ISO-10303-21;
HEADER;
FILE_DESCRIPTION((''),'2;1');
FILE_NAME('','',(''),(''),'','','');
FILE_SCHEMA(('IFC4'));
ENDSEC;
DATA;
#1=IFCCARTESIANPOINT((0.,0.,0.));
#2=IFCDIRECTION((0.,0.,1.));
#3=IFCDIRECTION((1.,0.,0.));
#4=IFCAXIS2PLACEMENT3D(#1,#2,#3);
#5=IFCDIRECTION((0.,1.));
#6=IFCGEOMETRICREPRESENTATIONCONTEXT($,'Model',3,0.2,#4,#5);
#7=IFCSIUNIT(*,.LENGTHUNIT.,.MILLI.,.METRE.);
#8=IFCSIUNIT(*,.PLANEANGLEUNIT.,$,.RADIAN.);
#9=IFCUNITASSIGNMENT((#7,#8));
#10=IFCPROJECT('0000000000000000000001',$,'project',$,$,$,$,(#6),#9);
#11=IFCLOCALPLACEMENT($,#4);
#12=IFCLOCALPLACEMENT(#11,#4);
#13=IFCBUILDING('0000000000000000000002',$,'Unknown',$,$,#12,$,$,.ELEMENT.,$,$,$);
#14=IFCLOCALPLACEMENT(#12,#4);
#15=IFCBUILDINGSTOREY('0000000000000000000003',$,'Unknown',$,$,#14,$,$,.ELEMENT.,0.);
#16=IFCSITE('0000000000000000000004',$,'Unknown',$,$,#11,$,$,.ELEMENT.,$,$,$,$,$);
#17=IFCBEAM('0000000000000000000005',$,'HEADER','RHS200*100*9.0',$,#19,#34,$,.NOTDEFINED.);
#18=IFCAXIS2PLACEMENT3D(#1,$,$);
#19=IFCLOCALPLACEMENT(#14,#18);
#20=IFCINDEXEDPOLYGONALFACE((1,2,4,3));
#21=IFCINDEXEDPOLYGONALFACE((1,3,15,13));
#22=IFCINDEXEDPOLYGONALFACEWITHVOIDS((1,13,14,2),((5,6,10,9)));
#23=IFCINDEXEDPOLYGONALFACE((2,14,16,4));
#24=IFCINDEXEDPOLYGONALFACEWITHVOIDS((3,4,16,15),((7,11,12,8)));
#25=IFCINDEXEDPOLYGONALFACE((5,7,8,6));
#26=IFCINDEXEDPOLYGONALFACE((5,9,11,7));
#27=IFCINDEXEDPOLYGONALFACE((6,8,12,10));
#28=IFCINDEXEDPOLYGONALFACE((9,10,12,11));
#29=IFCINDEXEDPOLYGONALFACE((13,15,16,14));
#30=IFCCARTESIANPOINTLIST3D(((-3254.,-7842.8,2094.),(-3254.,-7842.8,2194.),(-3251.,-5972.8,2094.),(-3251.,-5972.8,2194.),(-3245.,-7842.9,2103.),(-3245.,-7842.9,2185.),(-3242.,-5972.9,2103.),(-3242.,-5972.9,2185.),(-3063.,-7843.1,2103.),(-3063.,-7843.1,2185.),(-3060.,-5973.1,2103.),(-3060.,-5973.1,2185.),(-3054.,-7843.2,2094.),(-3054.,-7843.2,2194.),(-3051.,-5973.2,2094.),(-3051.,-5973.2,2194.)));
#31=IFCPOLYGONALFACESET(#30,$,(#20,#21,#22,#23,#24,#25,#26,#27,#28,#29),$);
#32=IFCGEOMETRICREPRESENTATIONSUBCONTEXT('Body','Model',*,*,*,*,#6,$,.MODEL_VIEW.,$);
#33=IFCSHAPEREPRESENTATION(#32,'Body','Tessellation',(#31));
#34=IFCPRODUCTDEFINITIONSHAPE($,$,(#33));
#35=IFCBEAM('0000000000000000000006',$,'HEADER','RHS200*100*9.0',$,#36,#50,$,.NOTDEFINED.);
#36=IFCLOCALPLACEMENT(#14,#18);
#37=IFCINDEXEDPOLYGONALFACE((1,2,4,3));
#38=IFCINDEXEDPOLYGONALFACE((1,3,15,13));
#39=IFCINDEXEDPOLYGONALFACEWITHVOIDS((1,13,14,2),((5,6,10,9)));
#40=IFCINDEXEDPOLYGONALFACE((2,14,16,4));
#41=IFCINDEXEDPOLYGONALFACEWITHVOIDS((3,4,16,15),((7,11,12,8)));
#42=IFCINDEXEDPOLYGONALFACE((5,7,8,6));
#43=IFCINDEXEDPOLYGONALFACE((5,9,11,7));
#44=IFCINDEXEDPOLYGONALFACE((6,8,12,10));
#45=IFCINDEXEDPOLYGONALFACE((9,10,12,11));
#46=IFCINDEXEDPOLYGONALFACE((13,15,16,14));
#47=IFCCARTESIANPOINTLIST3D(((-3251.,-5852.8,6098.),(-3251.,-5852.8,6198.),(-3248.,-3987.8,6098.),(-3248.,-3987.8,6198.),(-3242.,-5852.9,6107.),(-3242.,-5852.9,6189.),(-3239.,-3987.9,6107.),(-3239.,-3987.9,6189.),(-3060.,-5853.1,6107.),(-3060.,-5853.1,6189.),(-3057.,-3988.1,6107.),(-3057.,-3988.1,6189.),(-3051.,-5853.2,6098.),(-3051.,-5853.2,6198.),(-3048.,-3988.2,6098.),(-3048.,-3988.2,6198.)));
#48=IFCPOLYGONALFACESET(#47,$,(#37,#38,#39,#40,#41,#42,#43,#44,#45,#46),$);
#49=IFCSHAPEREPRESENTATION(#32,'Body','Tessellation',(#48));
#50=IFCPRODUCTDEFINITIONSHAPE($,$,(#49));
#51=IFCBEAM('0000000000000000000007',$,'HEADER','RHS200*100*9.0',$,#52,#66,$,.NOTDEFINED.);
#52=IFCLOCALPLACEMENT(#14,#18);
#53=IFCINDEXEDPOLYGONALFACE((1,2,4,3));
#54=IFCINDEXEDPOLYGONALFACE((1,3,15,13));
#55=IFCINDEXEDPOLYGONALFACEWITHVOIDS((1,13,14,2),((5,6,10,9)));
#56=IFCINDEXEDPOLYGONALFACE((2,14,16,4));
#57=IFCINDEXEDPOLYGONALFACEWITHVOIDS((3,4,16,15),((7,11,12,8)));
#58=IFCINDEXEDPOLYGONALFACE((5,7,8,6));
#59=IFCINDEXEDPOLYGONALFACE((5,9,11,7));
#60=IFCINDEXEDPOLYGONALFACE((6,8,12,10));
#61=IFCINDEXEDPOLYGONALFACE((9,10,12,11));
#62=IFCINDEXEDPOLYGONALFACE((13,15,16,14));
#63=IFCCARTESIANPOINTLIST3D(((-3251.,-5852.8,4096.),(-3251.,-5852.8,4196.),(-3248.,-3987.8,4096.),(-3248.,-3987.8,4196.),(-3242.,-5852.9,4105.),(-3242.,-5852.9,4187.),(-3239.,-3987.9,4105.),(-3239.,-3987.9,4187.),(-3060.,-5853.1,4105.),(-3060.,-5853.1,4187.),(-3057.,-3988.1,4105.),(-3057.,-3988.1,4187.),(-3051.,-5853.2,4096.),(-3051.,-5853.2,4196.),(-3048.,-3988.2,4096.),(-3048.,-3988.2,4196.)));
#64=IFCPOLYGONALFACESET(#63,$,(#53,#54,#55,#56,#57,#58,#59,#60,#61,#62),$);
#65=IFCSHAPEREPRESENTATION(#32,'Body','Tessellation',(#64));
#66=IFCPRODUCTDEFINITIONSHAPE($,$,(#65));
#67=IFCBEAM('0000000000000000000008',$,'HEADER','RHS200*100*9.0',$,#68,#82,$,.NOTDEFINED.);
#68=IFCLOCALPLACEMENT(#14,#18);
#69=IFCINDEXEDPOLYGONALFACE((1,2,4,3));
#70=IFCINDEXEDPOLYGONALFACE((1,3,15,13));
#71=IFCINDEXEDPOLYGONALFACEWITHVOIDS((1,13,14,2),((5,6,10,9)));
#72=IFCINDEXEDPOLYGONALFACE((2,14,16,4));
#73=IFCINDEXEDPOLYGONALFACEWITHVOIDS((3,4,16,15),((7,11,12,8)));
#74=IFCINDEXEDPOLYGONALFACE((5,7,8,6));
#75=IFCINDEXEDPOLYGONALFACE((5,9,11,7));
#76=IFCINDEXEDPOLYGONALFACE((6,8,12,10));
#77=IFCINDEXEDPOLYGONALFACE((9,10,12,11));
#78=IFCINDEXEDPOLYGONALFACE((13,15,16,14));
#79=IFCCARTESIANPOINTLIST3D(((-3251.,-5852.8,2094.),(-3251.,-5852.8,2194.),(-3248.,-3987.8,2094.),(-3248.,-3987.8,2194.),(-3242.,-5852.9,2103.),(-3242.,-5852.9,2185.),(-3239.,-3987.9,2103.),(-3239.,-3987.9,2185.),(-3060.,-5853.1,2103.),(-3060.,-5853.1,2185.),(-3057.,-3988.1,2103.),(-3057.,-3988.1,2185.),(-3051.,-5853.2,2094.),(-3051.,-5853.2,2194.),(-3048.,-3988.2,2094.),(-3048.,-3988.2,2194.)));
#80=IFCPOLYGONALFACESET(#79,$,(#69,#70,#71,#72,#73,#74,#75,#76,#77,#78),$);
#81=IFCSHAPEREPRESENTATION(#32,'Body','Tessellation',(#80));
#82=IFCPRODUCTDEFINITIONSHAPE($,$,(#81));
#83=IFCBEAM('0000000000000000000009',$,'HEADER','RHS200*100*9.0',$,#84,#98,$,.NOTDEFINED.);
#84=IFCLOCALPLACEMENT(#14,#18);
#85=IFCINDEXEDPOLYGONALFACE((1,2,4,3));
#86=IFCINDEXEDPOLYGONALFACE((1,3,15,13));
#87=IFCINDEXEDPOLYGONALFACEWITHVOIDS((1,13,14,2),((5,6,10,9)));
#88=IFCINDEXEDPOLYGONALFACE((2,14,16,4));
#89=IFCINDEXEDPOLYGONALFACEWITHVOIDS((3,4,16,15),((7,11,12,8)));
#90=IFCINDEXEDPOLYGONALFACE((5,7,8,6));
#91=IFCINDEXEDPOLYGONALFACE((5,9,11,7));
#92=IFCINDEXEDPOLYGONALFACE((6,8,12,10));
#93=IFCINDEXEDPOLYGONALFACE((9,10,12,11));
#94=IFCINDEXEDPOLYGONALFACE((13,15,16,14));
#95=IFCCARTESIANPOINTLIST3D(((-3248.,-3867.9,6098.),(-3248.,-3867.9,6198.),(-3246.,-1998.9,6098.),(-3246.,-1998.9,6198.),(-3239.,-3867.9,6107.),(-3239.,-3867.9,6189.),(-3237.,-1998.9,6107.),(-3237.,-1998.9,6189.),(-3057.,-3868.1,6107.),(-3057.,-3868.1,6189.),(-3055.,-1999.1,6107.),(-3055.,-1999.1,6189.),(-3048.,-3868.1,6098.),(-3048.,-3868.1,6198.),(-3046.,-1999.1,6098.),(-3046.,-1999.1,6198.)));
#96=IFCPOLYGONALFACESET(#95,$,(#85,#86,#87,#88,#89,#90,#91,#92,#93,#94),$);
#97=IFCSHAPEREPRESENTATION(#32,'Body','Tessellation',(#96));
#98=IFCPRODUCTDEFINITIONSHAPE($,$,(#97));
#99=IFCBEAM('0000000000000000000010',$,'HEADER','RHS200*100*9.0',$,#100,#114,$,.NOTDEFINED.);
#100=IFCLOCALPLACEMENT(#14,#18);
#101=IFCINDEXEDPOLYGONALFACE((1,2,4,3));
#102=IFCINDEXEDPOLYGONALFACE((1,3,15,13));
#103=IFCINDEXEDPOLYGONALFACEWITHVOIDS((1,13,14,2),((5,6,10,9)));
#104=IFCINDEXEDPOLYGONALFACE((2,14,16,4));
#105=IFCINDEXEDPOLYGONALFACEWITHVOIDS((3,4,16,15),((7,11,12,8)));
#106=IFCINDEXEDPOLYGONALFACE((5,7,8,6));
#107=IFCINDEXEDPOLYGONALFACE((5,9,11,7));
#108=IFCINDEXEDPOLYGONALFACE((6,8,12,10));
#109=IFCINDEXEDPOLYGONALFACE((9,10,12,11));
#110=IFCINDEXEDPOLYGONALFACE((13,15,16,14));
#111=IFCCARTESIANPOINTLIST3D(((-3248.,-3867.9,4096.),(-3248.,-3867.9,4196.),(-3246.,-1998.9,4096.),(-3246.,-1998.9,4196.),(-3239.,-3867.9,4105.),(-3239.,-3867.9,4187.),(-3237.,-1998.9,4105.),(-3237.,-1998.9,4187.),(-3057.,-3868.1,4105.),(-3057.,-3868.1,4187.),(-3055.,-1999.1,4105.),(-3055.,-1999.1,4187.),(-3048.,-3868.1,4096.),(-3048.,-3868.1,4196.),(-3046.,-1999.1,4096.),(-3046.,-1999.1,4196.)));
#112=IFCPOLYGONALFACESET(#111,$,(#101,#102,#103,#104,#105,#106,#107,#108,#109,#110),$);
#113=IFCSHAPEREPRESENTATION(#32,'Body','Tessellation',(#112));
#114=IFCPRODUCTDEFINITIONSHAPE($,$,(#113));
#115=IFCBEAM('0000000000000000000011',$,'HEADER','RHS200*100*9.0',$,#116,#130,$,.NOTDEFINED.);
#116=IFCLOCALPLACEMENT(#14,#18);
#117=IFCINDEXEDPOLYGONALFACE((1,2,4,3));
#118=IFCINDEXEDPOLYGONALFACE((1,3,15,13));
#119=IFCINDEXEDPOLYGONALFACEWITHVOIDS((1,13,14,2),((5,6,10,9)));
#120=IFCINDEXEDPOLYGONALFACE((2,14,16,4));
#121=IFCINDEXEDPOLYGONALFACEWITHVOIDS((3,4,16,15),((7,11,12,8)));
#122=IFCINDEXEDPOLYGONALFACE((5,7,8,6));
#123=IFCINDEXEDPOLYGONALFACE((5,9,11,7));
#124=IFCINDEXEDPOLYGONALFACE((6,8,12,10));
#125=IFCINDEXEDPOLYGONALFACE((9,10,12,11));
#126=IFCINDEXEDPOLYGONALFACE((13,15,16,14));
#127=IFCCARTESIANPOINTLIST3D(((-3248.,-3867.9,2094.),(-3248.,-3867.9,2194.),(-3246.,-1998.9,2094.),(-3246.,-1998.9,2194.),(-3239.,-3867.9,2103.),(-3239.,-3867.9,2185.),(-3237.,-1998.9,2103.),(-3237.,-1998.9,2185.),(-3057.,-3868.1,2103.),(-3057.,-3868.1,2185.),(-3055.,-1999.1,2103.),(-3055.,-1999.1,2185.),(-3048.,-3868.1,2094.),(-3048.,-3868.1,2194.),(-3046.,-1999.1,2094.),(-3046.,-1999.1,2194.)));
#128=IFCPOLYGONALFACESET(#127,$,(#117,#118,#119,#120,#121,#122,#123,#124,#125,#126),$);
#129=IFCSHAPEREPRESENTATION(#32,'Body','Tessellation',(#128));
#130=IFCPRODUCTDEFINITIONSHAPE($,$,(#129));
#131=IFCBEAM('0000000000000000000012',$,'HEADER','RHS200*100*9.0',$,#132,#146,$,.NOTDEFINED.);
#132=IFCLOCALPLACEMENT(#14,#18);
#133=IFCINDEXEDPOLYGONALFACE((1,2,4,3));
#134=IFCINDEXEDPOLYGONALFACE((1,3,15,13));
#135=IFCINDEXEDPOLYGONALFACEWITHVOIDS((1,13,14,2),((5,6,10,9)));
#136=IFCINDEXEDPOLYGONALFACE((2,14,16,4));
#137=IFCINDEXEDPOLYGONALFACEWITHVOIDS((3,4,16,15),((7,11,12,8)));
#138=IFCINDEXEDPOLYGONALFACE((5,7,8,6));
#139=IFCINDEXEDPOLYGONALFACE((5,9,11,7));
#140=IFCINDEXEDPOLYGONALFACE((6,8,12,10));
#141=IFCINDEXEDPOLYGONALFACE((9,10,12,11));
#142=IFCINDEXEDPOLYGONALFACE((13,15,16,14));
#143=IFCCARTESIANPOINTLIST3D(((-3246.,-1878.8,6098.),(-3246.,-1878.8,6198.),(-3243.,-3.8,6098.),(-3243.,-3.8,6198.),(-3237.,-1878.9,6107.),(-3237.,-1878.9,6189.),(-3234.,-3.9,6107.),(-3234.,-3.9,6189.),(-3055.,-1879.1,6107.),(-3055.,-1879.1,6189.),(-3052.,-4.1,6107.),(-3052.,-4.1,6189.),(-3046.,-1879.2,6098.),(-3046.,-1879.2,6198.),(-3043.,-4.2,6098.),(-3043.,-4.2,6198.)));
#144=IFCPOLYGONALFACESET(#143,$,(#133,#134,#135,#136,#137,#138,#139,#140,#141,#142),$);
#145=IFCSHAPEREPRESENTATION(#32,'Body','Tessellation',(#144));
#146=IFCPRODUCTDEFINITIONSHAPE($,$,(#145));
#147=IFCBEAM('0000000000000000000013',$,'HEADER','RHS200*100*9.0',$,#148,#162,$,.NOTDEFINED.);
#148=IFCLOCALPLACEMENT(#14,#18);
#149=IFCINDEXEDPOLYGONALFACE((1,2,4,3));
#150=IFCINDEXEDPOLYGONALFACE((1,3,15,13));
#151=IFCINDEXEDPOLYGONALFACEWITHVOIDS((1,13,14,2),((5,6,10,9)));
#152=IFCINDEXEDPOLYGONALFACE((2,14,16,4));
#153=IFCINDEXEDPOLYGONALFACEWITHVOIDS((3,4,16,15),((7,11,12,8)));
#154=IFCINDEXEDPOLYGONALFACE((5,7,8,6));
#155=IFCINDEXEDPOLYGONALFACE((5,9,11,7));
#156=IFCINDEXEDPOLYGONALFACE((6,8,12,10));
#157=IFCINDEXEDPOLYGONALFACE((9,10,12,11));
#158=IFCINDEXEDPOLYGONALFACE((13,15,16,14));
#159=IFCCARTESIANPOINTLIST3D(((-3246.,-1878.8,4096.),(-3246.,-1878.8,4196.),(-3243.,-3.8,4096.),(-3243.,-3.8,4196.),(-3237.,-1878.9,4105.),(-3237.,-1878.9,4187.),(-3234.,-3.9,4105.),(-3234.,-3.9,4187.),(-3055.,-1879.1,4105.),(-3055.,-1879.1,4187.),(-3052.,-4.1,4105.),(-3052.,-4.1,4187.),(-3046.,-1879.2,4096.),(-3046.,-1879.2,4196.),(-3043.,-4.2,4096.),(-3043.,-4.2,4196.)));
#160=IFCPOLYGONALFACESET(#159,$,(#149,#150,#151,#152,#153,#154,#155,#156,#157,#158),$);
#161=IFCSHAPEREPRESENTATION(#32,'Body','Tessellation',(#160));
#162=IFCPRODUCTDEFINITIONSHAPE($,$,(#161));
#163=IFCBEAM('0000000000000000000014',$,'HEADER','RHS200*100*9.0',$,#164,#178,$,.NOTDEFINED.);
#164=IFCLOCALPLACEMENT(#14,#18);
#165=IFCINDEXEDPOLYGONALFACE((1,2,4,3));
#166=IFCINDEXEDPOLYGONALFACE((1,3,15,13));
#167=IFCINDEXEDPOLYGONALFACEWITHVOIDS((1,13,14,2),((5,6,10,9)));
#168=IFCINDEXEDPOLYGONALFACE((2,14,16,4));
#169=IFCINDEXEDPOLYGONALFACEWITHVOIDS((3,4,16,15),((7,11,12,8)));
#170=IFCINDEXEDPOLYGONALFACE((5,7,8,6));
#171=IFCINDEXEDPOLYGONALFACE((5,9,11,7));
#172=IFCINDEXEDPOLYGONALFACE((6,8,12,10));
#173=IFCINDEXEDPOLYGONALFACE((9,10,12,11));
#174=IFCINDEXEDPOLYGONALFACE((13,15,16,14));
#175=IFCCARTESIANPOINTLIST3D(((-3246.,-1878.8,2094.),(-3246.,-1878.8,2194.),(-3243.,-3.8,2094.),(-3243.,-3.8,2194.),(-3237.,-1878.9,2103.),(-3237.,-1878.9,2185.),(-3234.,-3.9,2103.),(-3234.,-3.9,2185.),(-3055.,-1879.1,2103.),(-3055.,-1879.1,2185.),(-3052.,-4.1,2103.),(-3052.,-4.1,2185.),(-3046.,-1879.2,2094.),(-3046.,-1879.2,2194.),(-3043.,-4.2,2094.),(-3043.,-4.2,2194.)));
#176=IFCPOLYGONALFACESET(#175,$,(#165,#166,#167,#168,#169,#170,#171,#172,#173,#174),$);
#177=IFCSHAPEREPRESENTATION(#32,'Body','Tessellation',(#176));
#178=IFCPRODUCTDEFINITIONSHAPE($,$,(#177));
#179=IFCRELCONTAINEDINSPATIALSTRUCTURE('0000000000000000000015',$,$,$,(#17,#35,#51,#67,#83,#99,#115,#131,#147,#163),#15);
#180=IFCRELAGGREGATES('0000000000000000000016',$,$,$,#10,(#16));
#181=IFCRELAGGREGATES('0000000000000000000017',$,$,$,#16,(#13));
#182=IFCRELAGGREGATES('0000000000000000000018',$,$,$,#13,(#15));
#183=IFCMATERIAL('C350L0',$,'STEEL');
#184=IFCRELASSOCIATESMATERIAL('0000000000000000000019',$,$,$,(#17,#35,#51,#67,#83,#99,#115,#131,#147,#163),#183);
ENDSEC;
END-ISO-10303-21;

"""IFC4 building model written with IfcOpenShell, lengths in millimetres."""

from ifc_helpers import new_model, si_unit, direction, frame, origin_with_axes, place, context, subcontext, project, spatial, line, indexed_curve, outline, extrude, material, element, save


model = new_model("IFC4")

# Units and contexts
model_context = context("Model", 3, precision=0.2, world=origin_with_axes(), true_north=direction((0.0, 1.0)))
body_context = subcontext(model_context, "Body", "Model", "MODEL_VIEW")
ifc_project = project(units=[si_unit("LENGTHUNIT", "METRE", prefix="MILLI"), si_unit("PLANEANGLEUNIT", "RADIAN")], contexts=[model_context])

# Site, building, storey
site_placement = place(None, origin_with_axes())
site = spatial("IfcSite", under=ifc_project, at=site_placement, Name="Unknown", CompositionType="ELEMENT")
building_placement = place(site_placement, origin_with_axes())
building = spatial("IfcBuilding", under=site, at=building_placement, Name="Unknown", CompositionType="ELEMENT")
storey_placement = place(building_placement, origin_with_axes())
storey = spatial("IfcBuildingStorey", under=building, at=storey_placement, Name="Unknown", CompositionType="ELEMENT", Elevation=0.0)

# Shared definitions
ifc_material = material(Name="C350L0", Category="STEEL")

# Beams
for number, where, z_axis, x_axis, name in (
    (1, (-3151.0, -5973.0, 2144.0), (0.0, 0.0, 1.0), (-0.001604, -0.999999, 0.0), "HEADER"),
):
    element("IfcBeam", number, at=place(storey_placement, frame(where, z_axis=z_axis, x_axis=x_axis)), inside=storey, material=ifc_material, Name=name, Description="RHS200*100*9.0", PredefinedType="NOTDEFINED", context=body_context, shape_type="SolidModel", body=[
        extrude(outline(indexed_curve([(-50.0, -100.0), (50.0, -100.0), (50.0, 100.0), (-50.0, 100.0)], segments=[line(1, 2, 3, 4, 1)]), holes=[indexed_curve([(-41.0, -91.0), (-41.0, 91.0), (41.0, 91.0), (41.0, -91.0)], segments=[line(1, 2, 3, 4, 1)])]), frame((0.0, 0.0, 0.0), z_axis=(-1.0, 0.0, 0.0), x_axis=(0.0, 0.0, 1.0)), (0.0, 0.0, -1.0), 1870.0),
    ])
for number, where, z_axis, x_axis, name in (
    (2, (-3148.0, -3988.0, 6148.0), (0.0, 0.0, 1.0), (-0.001609, -0.999999, 0.0), "HEADER"),
    (3, (-3148.0, -3988.0, 4146.0), (0.0, 0.0, 1.0), (-0.001609, -0.999999, 0.0), "HEADER"),
    (4, (-3148.0, -3988.0, 2144.0), (0.0, 0.0, 1.0), (-0.001609, -0.999999, 0.0), "HEADER"),
):
    element("IfcBeam", number, at=place(storey_placement, frame(where, z_axis=z_axis, x_axis=x_axis)), inside=storey, material=ifc_material, Name=name, Description="RHS200*100*9.0", PredefinedType="NOTDEFINED", context=body_context, shape_type="SolidModel", body=[
        extrude(outline(indexed_curve([(-50.0, -100.0), (50.0, -100.0), (50.0, 100.0), (-50.0, 100.0)], segments=[line(1, 2, 3, 4, 1)]), holes=[indexed_curve([(-41.0, -91.0), (-41.0, 91.0), (41.0, 91.0), (41.0, -91.0)], segments=[line(1, 2, 3, 4, 1)])]), frame((0.0, 0.0, 0.0), z_axis=(-1.0, 0.0, 0.0), x_axis=(0.0, 0.0, 1.0)), (0.0, 0.0, -1.0), 1865.0),
    ])
for number, where, z_axis, x_axis, name in (
    (5, (-3146.0, -1999.0, 6148.0), (0.0, 0.0, 1.0), (-0.00107, -0.999999, 0.0), "HEADER"),
    (6, (-3146.0, -1999.0, 4146.0), (0.0, 0.0, 1.0), (-0.00107, -0.999999, 0.0), "HEADER"),
    (7, (-3146.0, -1999.0, 2144.0), (0.0, 0.0, 1.0), (-0.00107, -0.999999, 0.0), "HEADER"),
):
    element("IfcBeam", number, at=place(storey_placement, frame(where, z_axis=z_axis, x_axis=x_axis)), inside=storey, material=ifc_material, Name=name, Description="RHS200*100*9.0", PredefinedType="NOTDEFINED", context=body_context, shape_type="SolidModel", body=[
        extrude(outline(indexed_curve([(-50.0, -100.0), (50.0, -100.0), (50.0, 100.0), (-50.0, 100.0)], segments=[line(1, 2, 3, 4, 1)]), holes=[indexed_curve([(-41.0, -91.0), (-41.0, 91.0), (41.0, 91.0), (41.0, -91.0)], segments=[line(1, 2, 3, 4, 1)])]), frame((0.0, 0.0, 0.0), z_axis=(-1.0, 0.0, 0.0), x_axis=(0.0, 0.0, 1.0)), (0.0, 0.0, -1.0), 1869.0),
    ])
for number, where, z_axis, x_axis, name in (
    (8, (-3143.0, -4.0, 6148.0), (0.0, 0.0, 1.0), (-0.0016, -0.999999, 0.0), "HEADER"),
    (9, (-3143.0, -4.0, 4146.0), (0.0, 0.0, 1.0), (-0.0016, -0.999999, 0.0), "HEADER"),
    (10, (-3143.0, -4.0, 2144.0), (0.0, 0.0, 1.0), (-0.0016, -0.999999, 0.0), "HEADER"),
):
    element("IfcBeam", number, at=place(storey_placement, frame(where, z_axis=z_axis, x_axis=x_axis)), inside=storey, material=ifc_material, Name=name, Description="RHS200*100*9.0", PredefinedType="NOTDEFINED", context=body_context, shape_type="SolidModel", body=[
        extrude(outline(indexed_curve([(-50.0, -100.0), (50.0, -100.0), (50.0, 100.0), (-50.0, 100.0)], segments=[line(1, 2, 3, 4, 1)]), holes=[indexed_curve([(-41.0, -91.0), (-41.0, 91.0), (41.0, 91.0), (41.0, -91.0)], segments=[line(1, 2, 3, 4, 1)])]), frame((0.0, 0.0, 0.0), z_axis=(-1.0, 0.0, 0.0), x_axis=(0.0, 0.0, 1.0)), (0.0, 0.0, -1.0), 1875.0),
    ])

save(model, "model.ifc")
